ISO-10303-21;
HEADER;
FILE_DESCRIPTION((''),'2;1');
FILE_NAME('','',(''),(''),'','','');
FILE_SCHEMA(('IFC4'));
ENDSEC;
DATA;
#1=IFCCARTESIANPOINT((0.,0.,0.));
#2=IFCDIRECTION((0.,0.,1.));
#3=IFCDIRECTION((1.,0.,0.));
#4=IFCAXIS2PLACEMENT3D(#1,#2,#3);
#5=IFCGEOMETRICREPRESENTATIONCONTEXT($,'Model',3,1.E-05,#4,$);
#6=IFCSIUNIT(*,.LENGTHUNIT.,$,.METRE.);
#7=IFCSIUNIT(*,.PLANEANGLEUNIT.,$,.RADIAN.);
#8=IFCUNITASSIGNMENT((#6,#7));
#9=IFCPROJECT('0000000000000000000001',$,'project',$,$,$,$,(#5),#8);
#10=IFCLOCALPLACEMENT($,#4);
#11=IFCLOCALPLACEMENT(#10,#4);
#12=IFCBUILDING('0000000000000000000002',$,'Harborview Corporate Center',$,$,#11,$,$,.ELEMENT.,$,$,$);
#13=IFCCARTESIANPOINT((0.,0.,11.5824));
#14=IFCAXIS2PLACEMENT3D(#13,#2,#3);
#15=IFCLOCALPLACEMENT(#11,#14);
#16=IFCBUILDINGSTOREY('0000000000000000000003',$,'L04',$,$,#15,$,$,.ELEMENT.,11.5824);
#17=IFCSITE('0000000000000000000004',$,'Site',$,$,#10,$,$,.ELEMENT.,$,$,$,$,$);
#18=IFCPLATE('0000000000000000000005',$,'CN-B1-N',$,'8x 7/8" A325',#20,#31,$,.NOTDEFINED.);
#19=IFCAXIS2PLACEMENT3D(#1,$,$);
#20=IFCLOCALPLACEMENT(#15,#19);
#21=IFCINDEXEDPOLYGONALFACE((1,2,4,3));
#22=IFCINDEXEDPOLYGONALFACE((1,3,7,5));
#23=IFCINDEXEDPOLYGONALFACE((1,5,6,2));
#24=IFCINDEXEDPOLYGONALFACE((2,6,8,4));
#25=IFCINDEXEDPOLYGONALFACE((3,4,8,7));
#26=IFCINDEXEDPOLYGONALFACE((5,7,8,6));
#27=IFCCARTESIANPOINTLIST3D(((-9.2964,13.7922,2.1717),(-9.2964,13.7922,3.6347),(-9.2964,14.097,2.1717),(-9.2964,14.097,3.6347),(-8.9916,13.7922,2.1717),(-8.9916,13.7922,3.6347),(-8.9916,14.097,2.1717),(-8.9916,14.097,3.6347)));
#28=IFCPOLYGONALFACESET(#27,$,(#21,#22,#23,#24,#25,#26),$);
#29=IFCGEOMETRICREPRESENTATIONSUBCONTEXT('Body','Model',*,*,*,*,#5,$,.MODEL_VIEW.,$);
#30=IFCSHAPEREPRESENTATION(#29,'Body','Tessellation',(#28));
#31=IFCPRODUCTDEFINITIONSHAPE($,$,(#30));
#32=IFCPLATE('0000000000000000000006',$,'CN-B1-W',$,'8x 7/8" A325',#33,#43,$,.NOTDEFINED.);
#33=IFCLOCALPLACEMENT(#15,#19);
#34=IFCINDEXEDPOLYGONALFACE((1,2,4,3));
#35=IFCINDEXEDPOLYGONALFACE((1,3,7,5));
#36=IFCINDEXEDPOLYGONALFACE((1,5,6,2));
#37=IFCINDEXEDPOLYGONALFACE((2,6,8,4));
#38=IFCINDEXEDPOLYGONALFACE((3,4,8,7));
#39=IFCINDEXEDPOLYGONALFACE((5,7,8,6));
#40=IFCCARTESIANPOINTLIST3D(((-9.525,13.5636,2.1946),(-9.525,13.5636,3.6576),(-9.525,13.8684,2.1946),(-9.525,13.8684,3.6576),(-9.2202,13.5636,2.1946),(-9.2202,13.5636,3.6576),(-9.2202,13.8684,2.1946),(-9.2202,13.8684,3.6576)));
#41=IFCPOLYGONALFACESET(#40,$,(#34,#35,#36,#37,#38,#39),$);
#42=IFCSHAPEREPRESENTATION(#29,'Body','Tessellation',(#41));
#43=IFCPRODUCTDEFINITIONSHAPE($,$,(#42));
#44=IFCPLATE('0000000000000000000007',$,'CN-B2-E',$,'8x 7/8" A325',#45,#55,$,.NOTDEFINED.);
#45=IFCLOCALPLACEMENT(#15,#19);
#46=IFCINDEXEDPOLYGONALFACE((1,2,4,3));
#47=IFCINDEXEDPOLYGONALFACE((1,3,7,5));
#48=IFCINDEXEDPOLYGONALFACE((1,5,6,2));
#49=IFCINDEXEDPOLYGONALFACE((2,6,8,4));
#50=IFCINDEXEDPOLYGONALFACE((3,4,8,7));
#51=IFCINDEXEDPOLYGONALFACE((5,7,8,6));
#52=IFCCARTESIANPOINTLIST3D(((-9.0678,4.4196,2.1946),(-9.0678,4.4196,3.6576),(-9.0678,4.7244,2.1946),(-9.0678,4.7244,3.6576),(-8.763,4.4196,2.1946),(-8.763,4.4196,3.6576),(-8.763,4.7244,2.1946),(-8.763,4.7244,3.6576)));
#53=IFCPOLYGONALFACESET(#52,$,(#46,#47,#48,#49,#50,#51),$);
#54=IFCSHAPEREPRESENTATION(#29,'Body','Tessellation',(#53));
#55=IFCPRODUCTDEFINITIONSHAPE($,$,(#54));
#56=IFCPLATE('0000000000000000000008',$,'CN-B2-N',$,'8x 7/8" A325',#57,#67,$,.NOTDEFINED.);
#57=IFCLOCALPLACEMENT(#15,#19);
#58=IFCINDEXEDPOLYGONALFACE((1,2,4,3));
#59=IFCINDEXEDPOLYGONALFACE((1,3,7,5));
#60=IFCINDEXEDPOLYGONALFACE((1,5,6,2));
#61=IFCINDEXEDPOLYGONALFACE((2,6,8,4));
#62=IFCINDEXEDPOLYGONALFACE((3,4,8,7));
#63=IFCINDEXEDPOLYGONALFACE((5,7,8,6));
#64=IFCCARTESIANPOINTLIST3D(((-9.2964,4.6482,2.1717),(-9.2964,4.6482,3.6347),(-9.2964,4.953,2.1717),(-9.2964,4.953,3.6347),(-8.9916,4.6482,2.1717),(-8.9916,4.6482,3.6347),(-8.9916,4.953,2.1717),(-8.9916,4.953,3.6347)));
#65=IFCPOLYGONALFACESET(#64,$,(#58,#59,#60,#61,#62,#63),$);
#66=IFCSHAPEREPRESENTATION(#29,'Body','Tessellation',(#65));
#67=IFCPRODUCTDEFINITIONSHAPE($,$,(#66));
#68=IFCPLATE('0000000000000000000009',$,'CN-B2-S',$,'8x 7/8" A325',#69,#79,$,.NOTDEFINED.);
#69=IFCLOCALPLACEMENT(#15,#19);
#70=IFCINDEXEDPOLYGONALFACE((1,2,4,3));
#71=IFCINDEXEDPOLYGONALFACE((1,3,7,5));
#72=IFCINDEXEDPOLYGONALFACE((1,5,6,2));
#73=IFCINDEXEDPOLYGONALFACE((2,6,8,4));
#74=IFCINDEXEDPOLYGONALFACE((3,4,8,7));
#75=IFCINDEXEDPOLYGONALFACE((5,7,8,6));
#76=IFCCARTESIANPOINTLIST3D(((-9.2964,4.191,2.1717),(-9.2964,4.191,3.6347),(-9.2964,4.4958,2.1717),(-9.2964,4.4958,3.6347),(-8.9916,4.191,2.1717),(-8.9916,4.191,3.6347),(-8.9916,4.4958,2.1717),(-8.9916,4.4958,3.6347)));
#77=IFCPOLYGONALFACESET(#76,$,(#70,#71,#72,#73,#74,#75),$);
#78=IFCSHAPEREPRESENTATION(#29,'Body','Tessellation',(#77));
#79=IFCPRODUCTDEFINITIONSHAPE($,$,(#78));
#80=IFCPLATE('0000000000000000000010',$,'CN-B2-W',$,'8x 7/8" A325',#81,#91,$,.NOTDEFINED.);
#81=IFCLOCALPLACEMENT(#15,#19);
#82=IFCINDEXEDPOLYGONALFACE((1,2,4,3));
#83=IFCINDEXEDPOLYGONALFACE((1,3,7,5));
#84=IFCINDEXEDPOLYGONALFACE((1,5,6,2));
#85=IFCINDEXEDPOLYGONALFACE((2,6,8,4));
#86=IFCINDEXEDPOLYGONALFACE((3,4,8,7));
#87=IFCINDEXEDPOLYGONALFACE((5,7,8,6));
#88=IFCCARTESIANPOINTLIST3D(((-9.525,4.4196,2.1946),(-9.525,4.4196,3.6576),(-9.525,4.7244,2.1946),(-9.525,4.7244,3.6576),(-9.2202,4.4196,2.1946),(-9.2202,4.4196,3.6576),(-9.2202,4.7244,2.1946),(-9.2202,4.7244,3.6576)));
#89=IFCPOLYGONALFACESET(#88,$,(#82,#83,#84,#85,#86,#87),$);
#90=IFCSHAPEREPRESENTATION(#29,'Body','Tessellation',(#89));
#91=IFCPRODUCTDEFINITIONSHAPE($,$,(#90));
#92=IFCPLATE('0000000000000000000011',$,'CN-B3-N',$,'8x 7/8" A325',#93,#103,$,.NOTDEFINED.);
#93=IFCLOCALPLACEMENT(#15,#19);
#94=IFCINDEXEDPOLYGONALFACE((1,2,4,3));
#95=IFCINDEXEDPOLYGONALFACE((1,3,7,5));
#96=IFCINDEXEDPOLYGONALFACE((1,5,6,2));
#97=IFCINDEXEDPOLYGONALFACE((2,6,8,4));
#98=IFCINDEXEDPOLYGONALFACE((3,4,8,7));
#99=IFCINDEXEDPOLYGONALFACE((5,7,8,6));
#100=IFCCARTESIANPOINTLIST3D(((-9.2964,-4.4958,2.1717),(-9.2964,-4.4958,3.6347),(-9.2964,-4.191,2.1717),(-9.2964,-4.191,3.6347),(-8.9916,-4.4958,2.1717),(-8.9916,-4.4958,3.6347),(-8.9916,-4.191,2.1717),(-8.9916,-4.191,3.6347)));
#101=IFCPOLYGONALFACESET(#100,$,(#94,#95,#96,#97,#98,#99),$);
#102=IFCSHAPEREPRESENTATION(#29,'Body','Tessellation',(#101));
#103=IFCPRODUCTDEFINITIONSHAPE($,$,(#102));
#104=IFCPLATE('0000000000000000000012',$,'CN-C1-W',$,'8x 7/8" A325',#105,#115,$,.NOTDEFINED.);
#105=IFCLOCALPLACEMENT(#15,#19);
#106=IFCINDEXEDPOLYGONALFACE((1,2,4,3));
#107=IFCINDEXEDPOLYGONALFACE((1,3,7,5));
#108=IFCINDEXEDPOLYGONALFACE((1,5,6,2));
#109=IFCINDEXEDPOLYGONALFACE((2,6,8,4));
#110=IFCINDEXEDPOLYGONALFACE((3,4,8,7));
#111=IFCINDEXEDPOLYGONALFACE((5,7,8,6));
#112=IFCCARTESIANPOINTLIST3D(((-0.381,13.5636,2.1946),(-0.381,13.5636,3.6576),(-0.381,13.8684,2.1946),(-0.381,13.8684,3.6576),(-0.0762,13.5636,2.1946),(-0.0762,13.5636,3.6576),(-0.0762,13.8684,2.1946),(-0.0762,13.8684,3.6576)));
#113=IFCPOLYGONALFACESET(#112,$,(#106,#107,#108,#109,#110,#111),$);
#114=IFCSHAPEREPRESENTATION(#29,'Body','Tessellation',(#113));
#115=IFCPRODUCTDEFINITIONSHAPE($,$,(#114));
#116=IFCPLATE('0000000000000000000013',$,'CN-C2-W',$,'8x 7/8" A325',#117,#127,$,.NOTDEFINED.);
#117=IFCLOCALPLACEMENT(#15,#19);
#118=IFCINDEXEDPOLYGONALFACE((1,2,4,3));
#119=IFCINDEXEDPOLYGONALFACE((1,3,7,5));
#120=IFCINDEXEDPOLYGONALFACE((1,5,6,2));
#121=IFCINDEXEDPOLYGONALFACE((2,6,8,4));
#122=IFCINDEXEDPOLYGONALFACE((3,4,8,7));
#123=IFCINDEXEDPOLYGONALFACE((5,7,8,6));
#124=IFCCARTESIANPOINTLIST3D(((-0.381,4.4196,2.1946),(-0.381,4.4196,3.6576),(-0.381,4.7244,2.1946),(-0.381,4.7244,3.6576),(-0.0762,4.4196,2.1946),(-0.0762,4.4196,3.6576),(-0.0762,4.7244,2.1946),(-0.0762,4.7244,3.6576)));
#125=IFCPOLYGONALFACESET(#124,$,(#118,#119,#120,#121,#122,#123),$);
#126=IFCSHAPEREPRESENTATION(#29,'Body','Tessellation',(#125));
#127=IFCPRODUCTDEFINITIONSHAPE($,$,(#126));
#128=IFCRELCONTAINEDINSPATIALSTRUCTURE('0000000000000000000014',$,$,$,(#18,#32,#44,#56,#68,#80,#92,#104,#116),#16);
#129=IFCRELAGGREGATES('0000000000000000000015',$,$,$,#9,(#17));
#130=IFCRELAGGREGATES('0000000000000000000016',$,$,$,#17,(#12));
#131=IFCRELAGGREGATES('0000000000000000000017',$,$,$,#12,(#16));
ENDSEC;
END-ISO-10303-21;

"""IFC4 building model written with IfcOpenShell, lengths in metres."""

from ifc_helpers import new_model, si_unit, frame, origin_with_axes, place, context, subcontext, project, spatial, rectangle, extrude, element, save


model = new_model("IFC4")

# Units and contexts
model_context = context("Model", 3, precision=1e-05, world=origin_with_axes())
body_context = subcontext(model_context, "Body", "Model", "MODEL_VIEW")
ifc_project = project(units=[si_unit("LENGTHUNIT", "METRE"), si_unit("PLANEANGLEUNIT", "RADIAN")], contexts=[model_context])

# Site, building, storey
site_placement = place(None, origin_with_axes())
site = spatial("IfcSite", under=ifc_project, at=site_placement, Name="Site", CompositionType="ELEMENT")
building_placement = place(site_placement, origin_with_axes())
building = spatial("IfcBuilding", under=site, at=building_placement, Name="Harborview Corporate Center", CompositionType="ELEMENT")
storey_placement = place(building_placement, frame((0.0, 0.0, 11.5824), z_axis=(0.0, 0.0, 1.0), x_axis=(1.0, 0.0, 0.0)))
storey = spatial("IfcBuildingStorey", under=building, at=storey_placement, Name="L04", CompositionType="ELEMENT", Elevation=11.5824)

# Plates
for number, where, z_axis, x_axis, name in (
    (1, (-9.144, 13.9446, 2.1717), (0.0, 0.0, 1.0), (1.0, 0.0, 0.0), "CN-B1-N"),
    (2, (-9.3726, 13.716, 2.1946), (0.0, 0.0, 1.0), (1.0, 0.0, 0.0), "CN-B1-W"),
    (3, (-8.9154, 4.572, 2.1946), (0.0, 0.0, 1.0), (1.0, 0.0, 0.0), "CN-B2-E"),
    (4, (-9.144, 4.8006, 2.1717), (0.0, 0.0, 1.0), (1.0, 0.0, 0.0), "CN-B2-N"),
    (5, (-9.144, 4.3434, 2.1717), (0.0, 0.0, 1.0), (1.0, 0.0, 0.0), "CN-B2-S"),
    (6, (-9.3726, 4.572, 2.1946), (0.0, 0.0, 1.0), (1.0, 0.0, 0.0), "CN-B2-W"),
    (7, (-9.144, -4.3434, 2.1717), (0.0, 0.0, 1.0), (1.0, 0.0, 0.0), "CN-B3-N"),
):
    element("IfcPlate", number, at=place(storey_placement, frame(where, z_axis=z_axis, x_axis=x_axis)), inside=storey, Name=name, ObjectType="8x 7/8\" A325", PredefinedType="NOTDEFINED", context=body_context, shape_type="SweptSolid", body=[
        extrude(rectangle(XDim=0.3048, YDim=0.3048), origin_with_axes(), (0.0, 0.0, 1.0), 1.463),
    ])
for number, where, z_axis, x_axis, name in (
    (8, (-0.2286, 13.716, 2.1946), (0.0, 0.0, 1.0), (1.0, 0.0, 0.0), "CN-C1-W"),
    (9, (-0.2286, 4.572, 2.1946), (0.0, 0.0, 1.0), (1.0, 0.0, 0.0), "CN-C2-W"),
):
    element("IfcPlate", number, at=place(storey_placement, frame(where, z_axis=z_axis, x_axis=x_axis)), inside=storey, Name=name, ObjectType="8x 7/8\" A325", PredefinedType="NOTDEFINED", context=body_context, shape_type="SweptSolid", body=[
        extrude(rectangle(XDim=0.3048, YDim=0.3048), origin_with_axes(), (0.0, 0.0, 1.0), 1.463),
    ])

save(model, "model.ifc")
